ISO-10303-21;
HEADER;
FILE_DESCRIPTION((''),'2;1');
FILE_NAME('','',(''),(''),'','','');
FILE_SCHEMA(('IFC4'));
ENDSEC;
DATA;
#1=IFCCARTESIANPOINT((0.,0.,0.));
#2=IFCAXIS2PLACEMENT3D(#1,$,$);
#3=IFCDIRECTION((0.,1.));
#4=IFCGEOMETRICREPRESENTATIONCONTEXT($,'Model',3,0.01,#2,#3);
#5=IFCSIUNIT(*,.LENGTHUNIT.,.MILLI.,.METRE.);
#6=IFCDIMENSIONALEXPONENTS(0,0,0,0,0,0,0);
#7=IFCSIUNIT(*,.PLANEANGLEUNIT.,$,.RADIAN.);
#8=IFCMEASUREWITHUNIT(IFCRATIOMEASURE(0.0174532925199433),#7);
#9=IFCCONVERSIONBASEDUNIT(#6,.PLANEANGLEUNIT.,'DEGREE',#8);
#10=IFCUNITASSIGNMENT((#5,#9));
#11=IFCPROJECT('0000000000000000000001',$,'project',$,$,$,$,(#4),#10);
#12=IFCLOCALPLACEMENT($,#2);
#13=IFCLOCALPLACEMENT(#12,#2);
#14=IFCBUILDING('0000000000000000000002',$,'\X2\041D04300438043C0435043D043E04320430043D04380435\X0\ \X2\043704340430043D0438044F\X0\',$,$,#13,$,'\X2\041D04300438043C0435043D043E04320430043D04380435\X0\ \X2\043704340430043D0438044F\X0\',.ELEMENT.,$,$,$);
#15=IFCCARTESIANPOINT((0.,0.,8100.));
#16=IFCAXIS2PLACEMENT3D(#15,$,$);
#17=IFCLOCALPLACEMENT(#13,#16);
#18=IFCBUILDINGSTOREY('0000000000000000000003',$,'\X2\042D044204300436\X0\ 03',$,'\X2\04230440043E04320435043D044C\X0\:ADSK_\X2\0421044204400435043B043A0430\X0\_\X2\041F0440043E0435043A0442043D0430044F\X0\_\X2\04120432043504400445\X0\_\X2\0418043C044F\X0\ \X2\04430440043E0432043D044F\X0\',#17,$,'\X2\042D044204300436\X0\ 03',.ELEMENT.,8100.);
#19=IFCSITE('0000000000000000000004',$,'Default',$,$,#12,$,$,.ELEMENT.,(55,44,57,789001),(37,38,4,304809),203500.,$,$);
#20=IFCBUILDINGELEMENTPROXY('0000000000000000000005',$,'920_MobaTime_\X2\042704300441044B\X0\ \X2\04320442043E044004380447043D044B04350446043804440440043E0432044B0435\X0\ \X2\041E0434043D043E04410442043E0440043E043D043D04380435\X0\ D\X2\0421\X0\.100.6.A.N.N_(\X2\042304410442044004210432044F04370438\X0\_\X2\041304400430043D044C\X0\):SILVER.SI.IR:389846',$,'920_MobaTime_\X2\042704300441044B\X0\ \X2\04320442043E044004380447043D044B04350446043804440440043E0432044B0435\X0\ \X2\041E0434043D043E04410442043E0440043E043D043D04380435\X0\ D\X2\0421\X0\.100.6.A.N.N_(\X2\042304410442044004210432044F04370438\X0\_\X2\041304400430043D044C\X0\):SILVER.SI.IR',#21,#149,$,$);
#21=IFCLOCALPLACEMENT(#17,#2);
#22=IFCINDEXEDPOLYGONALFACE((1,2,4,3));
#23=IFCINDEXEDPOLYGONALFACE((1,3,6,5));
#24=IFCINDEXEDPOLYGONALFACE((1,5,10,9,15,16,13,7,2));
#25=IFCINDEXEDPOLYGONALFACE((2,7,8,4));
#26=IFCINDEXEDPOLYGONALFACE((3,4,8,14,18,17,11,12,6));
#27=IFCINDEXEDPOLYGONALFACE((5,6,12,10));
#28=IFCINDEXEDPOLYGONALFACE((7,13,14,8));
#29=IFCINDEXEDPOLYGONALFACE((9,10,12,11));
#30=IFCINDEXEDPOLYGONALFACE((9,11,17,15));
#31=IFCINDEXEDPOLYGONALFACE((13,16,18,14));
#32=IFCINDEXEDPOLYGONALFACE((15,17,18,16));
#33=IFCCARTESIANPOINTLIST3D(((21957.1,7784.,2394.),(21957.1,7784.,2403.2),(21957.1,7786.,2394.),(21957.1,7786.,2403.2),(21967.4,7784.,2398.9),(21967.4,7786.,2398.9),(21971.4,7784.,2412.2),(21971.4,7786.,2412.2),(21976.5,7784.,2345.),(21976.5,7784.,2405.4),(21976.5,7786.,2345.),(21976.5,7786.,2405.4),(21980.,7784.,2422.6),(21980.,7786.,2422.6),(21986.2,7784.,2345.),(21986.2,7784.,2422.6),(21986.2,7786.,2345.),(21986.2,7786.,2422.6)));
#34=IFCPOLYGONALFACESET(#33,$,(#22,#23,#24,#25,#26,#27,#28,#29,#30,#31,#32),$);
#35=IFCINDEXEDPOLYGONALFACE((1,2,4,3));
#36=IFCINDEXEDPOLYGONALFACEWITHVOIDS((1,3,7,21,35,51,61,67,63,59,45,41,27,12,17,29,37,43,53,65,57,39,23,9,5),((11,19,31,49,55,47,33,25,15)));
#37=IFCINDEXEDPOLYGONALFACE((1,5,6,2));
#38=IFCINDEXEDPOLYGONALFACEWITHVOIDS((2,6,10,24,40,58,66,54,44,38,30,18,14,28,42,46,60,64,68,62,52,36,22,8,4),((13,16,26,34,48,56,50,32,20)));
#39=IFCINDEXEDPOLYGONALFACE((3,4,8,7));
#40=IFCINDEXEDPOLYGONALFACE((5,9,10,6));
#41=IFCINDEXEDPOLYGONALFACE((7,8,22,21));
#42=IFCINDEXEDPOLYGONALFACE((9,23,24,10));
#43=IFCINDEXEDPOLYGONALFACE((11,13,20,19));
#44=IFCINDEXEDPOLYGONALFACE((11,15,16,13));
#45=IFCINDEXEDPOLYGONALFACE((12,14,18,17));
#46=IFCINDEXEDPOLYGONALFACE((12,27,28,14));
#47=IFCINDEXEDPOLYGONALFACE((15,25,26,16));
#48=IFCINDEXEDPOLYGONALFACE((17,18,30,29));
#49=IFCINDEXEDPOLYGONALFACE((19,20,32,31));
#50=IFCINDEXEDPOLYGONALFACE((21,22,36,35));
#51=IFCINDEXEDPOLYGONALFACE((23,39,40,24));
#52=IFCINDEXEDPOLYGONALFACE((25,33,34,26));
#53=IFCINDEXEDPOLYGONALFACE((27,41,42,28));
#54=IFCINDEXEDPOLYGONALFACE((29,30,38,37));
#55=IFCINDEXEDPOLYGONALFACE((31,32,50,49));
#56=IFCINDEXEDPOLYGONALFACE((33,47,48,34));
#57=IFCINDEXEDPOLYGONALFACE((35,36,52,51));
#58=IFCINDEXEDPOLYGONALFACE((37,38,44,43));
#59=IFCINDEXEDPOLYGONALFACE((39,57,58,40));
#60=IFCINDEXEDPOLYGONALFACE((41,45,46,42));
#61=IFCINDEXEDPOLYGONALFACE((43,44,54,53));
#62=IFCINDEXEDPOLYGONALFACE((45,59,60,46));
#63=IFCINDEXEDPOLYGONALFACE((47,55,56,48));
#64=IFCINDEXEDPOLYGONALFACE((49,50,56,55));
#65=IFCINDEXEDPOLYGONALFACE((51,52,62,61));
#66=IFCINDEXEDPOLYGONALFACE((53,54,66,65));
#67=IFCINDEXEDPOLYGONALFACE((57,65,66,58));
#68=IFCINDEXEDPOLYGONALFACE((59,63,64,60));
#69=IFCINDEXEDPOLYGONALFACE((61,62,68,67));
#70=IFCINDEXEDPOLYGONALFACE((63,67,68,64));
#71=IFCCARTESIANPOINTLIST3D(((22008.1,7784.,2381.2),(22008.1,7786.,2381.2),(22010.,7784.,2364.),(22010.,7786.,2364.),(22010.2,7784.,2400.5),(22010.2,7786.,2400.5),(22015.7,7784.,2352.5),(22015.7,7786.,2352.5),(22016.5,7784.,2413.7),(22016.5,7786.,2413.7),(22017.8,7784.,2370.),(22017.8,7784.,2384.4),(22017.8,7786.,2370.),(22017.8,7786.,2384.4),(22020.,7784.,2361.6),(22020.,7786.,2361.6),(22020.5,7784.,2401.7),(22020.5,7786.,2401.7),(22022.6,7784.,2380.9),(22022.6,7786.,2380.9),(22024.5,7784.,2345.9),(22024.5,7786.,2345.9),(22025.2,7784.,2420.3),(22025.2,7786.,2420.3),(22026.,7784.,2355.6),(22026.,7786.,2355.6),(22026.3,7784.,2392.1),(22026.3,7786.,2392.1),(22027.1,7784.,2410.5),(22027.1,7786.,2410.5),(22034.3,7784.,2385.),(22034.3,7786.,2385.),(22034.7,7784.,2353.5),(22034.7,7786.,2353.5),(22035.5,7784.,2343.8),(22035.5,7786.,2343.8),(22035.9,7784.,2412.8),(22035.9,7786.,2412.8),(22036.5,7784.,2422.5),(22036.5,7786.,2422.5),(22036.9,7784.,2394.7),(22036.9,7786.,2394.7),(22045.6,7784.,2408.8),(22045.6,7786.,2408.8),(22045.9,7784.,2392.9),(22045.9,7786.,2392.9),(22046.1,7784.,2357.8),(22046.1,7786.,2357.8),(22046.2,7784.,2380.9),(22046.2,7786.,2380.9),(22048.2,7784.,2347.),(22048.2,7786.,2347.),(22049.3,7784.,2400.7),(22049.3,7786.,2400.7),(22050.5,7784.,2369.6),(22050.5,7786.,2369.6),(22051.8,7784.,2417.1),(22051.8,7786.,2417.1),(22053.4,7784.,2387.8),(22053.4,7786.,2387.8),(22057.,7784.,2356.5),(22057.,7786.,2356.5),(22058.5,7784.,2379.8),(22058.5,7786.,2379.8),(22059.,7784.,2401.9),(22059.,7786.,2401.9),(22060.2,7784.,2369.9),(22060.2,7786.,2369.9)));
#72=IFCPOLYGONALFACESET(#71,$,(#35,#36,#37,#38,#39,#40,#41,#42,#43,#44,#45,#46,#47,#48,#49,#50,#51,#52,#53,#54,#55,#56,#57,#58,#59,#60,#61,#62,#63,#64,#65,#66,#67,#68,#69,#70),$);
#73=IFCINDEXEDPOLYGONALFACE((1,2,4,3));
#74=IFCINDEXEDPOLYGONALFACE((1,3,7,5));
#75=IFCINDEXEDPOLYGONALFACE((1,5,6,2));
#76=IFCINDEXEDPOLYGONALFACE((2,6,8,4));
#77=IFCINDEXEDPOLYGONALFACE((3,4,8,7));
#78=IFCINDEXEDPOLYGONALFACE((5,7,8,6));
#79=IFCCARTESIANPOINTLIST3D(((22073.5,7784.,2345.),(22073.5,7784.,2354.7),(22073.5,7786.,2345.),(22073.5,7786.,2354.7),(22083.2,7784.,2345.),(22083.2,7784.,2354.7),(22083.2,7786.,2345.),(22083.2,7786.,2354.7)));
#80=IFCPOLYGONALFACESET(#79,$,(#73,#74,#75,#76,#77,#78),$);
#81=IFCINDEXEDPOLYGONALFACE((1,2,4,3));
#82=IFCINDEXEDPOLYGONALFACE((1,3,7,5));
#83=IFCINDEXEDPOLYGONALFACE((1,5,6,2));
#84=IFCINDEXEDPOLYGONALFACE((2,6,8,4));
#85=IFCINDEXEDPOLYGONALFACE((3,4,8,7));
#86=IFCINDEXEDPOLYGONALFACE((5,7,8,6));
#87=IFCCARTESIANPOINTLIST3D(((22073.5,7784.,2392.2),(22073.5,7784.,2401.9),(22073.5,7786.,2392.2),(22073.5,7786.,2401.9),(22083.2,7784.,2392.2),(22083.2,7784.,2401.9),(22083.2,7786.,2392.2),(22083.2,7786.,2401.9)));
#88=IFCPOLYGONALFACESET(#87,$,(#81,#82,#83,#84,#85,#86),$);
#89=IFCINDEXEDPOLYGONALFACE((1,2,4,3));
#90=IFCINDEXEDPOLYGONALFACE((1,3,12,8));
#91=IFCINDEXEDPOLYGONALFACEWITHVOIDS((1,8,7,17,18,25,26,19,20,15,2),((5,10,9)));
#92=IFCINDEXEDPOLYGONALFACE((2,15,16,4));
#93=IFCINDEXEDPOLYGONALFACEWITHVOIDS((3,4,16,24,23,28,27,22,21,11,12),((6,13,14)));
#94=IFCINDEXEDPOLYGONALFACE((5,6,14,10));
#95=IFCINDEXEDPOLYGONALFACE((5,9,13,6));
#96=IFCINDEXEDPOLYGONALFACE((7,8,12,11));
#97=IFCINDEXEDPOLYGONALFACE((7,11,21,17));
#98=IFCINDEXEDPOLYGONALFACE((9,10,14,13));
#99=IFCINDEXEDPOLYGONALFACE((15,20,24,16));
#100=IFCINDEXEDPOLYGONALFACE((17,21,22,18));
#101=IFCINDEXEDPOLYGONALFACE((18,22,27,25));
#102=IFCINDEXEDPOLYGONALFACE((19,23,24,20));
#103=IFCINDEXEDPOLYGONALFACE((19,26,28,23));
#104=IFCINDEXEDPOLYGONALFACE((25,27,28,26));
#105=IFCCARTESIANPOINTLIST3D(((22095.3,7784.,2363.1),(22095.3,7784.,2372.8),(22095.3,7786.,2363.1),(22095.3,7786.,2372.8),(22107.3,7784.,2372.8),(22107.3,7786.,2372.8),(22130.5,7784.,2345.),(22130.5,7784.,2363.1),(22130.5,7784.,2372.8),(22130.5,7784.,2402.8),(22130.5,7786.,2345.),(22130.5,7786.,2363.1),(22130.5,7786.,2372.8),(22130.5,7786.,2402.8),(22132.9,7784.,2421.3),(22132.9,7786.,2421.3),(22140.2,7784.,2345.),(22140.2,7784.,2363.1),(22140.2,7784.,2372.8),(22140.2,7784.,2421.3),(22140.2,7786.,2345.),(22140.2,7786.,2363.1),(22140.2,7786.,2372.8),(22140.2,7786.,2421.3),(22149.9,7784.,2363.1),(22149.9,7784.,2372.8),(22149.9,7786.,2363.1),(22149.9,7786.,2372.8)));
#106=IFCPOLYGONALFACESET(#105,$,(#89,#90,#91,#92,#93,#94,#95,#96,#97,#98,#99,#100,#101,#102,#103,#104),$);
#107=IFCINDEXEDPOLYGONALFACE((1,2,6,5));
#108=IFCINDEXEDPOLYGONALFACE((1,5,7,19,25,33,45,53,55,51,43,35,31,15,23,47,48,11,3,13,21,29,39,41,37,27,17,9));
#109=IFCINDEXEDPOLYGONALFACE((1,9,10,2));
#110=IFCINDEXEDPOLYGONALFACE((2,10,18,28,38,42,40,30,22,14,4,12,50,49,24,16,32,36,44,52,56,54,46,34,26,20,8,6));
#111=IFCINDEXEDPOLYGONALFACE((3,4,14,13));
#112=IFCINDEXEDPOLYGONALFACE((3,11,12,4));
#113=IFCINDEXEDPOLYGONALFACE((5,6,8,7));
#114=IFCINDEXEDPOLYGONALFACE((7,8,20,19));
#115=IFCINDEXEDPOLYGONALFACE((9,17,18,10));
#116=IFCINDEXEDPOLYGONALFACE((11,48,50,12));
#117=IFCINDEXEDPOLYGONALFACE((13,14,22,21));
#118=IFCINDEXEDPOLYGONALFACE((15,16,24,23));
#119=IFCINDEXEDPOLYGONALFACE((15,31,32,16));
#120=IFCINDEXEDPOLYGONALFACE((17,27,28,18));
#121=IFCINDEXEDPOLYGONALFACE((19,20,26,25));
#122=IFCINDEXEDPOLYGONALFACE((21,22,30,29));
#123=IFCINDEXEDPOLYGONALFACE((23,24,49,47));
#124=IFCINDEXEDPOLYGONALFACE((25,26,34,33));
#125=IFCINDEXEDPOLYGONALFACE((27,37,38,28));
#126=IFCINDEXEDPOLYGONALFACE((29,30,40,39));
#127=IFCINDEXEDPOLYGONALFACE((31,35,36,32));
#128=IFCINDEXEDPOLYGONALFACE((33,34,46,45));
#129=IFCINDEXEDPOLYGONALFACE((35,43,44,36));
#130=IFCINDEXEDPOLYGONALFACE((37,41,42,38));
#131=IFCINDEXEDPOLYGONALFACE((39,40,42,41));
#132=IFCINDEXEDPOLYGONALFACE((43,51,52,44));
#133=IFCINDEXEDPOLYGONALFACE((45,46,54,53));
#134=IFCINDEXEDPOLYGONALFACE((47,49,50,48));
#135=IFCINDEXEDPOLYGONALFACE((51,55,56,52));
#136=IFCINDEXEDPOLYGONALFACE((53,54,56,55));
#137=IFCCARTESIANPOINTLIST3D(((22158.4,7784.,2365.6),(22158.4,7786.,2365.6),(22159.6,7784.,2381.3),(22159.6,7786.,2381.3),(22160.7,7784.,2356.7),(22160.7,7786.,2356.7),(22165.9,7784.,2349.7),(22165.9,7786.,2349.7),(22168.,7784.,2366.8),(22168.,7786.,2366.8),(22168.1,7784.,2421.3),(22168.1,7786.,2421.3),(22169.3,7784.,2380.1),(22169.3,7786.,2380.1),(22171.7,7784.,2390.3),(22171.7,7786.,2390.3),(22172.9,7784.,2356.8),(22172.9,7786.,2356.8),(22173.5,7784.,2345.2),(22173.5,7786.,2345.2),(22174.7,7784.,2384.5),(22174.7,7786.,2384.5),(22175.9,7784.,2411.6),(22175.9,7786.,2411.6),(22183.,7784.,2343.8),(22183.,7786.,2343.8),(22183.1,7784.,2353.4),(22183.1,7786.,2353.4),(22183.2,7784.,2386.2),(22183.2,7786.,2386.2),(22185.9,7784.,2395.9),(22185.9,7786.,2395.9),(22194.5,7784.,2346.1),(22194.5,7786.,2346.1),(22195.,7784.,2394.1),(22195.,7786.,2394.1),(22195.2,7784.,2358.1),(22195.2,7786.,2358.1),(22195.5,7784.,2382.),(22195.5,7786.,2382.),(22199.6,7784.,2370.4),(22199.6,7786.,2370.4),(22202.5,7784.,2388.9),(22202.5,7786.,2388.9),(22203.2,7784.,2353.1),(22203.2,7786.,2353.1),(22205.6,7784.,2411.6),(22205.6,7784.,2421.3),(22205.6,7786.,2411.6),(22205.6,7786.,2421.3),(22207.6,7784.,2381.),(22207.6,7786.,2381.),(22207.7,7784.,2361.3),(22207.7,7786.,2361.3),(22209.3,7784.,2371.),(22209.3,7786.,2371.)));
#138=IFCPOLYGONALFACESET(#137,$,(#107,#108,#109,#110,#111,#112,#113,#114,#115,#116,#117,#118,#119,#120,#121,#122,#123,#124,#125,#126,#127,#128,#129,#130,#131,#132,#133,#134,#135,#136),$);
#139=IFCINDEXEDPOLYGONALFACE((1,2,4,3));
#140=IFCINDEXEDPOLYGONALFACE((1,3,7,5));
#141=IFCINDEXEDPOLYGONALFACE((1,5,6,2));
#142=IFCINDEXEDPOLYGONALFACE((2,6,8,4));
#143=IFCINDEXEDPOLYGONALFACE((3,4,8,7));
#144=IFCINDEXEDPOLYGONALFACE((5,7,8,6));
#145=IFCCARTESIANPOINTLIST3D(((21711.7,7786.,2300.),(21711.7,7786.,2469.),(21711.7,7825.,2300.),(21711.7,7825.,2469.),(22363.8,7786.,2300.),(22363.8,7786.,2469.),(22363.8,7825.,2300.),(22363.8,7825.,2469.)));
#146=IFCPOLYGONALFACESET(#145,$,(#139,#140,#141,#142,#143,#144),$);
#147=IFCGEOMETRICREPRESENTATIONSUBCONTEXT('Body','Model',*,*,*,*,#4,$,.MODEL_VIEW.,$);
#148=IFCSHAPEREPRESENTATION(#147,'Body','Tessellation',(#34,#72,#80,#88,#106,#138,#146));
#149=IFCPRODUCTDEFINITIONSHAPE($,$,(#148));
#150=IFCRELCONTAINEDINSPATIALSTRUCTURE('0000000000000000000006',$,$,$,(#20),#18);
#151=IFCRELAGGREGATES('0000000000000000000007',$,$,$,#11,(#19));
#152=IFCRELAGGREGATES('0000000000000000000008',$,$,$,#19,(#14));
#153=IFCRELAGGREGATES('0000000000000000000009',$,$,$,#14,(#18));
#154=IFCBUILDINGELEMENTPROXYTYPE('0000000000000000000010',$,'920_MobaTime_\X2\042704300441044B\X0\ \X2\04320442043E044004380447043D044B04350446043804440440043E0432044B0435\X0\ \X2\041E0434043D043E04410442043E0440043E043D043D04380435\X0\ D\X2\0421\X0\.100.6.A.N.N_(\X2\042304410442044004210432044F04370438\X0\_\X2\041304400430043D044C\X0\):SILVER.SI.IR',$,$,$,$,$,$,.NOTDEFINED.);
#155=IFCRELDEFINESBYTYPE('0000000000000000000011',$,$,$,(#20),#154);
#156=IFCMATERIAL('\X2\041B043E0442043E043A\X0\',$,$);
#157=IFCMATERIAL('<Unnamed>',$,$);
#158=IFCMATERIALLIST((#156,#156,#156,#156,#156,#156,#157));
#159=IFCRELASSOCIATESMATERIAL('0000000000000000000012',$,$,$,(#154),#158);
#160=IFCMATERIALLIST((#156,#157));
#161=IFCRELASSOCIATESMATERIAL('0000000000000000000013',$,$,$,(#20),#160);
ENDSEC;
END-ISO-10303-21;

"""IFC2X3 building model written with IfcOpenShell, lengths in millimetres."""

from ifc_helpers import new_model, entity, si_unit, converted_unit, direction, frame, origin, origin_2d_with_axis, place, context, subcontext, project, spatial, polyline, rectangle, outline, extrude, source, transform, mapped, material, material_list, type_object, type_shapes, element, save


model = new_model("IFC2X3")

# Units and contexts
model_context = context("Model", 3, precision=0.01, world=origin(), true_north=direction((0.0, 1.0)))
body_context = subcontext(model_context, "Body", "Model", "MODEL_VIEW")
ifc_project = project(units=[si_unit("LENGTHUNIT", "METRE", prefix="MILLI"), converted_unit("PLANEANGLEUNIT", "DEGREE", entity("IfcRatioMeasure", 0.0174532925199433), si_unit("PLANEANGLEUNIT", "RADIAN"), dimensions=[0, 0, 0, 0, 0, 0, 0])], contexts=[model_context])

# Site, building, storey
site_placement = place(None, origin())
site = spatial("IfcSite", under=ifc_project, at=site_placement, Name="Default", CompositionType="ELEMENT", RefLatitude=(55, 44, 57, 789001), RefLongitude=(37, 38, 4, 304809), RefElevation=203500.0)
building_placement = place(site_placement, origin())
building = spatial("IfcBuilding", under=site, at=building_placement, Name="Наименование здания", LongName="Наименование здания", CompositionType="ELEMENT")
storey_placement = place(building_placement, frame((0.0, 0.0, 8100.0)))
storey = spatial("IfcBuildingStorey", under=building, at=storey_placement, Name="Этаж 03", ObjectType="Уровень:ADSK_Стрелка_Проектная_Вверх_Имя уровня", LongName="Этаж 03", CompositionType="ELEMENT", Elevation=8100.0)

# Building element proxy
ifc_material_1 = material(Name="Лоток")
ifc_material_2 = material(Name="<Unnamed>")
ifc_material_list_1 = material_list([ifc_material_1, ifc_material_1, ifc_material_1, ifc_material_1, ifc_material_1, ifc_material_1, ifc_material_2])
building_element_proxy_type = type_object("IfcBuildingElementProxyType", Name="920_MobaTime_Часы вторичныецифровые Односторонние DС.100.6.A.N.N_(УстрСвязи_Грань):SILVER.SI.IR", PredefinedType="NOTDEFINED", material=ifc_material_list_1)
shared_shape = source(origin(), body_context, "Body", "SweptSolid", [
    extrude(outline(polyline([(-49.3, -13.1), (28.2, -13.1), (28.2, -6.8), (17.9, 1.8), (8.8, 16.0), (-0.3, 16.0), (4.6, 5.8), (11.1, -3.4), (-49.3, -3.4), (-49.3, -13.1)])), frame((-64.6, 9.8, 39.0), z_axis=(0.0, 0.0, 1.0), x_axis=(0.0, 1.0, 0.0)), (0.0, 0.0, 1.0), 2.0),
    extrude(outline(polyline([(2.2, -27.6), (19.0, -27.6), (30.5, -16.1), (33.3, -4.9), (31.0, 5.8), (21.8, 17.2), (5.2, 27.3), (-11.1, 33.0), (-24.0, 32.7), (-33.6, 27.6), (-40.3, 18.6), (-42.8, 5.7), (-38.0, -6.3), (-27.2, -14.9), (-17.5, -17.7), (-8.2, -16.4), (-0.3, -11.9), (5.1, -4.5), (7.3, 6.2), (4.0, 17.2), (18.4, 7.3), (23.6, -2.4), (22.0, -11.4), (14.2, -18.4), (5.3, -18.3), (2.2, -27.6)]), holes=[polyline([(-9.0, 23.3), (-1.3, 14.3), (-2.5, 2.0), (-11.4, -7.0), (-23.4, -6.0), (-32.2, 2.9), (-31.2, 15.1), (-25.6, 22.1), (-17.5, 24.9), (-9.0, 23.3)])]), frame((-2.7, 3.6, 39.0), z_axis=(0.0, 0.0, 1.0), x_axis=(-0.427649, 0.903945, 0.0)), (0.0, 0.0, 1.0), 2.0),
    extrude(rectangle(XDim=9.7, YDim=9.7, at=origin_2d_with_axis()), frame((40.6, -34.7, 39.0)), (0.0, 0.0, 1.0), 2.0),
    extrude(rectangle(XDim=9.7, YDim=9.7, at=origin_2d_with_axis()), frame((40.6, 12.6, 39.0)), (0.0, 0.0, 1.0), 2.0),
    extrude(outline(polyline([(-0.9, -28.1), (8.8, -28.1), (8.8, -9.9), (18.5, -9.9), (18.5, -0.2), (8.8, -0.2), (8.8, 48.3), (1.5, 48.3), (-36.0, -0.2), (-36.0, -9.9), (-0.9, -9.9), (-0.9, -28.1)]), holes=[polyline([(-0.9, -0.2), (-24.1, -0.2), (-0.9, 29.7), (-0.9, -0.2)])]), frame((93.6, -11.4, 39.0)), (0.0, 0.0, 1.0), 2.0),
    extrude(outline(polyline([(3.3, -28.3), (12.5, -28.3), (20.5, -25.0), (26.8, -18.9), (30.7, -10.0), (31.4, 1.6), (26.9, 11.8), (20.1, 18.4), (11.1, 22.3), (1.0, 23.3), (-7.9, 20.4), (-14.9, 14.5), (-18.9, 6.2), (-17.1, -9.0), (-36.7, 0.5), (-29.1, 29.2), (-38.5, 31.7), (-48.1, -4.6), (-11.6, -23.1), (-8.0, -14.0), (-10.8, -7.6), (-10.2, 1.1), (-3.0, 11.8), (9.2, 12.8), (20.0, 5.5), (21.4, -7.5), (15.5, -16.4), (4.6, -18.6), (3.3, -28.3)])), frame((147.1, -8.5, 39.0), z_axis=(0.0, 0.0, 1.0), x_axis=(0.256974, -0.966418, 0.0)), (0.0, 0.0, 1.0), 2.0),
    extrude(rectangle(XDim=652.0, YDim=169.0, at=origin_2d_with_axis()), frame((0.0, 0.0, 0.0), z_axis=(0.0, 0.0, 1.0), x_axis=(-1.0, 0.0, 0.0)), (0.0, 0.0, 1.0), 39.0),
])
type_shapes(building_element_proxy_type, [shared_shape])
ifc_material_list_2 = material_list([ifc_material_1, ifc_material_2])
for number, where, z_axis, x_axis, name in (
    (1, (22037.8, 7825.0, 2384.5), (0.0, -1.0, 0.0), (1.0, 0.0, 0.0), "920_MobaTime_Часы вторичныецифровые Односторонние DС.100.6.A.N.N_(УстрСвязи_Грань):SILVER.SI.IR:389846"),
):
    element("IfcBuildingElementProxy", number, at=place(storey_placement, frame(where, z_axis=z_axis, x_axis=x_axis)), inside=storey, type_object=building_element_proxy_type, material=ifc_material_list_2, Name=name, ObjectType="920_MobaTime_Часы вторичныецифровые Односторонние DС.100.6.A.N.N_(УстрСвязи_Грань):SILVER.SI.IR", context=body_context, shape_type="MappedRepresentation", body=[
        mapped(shared_shape, transform((0.0, 0.0, 0.0), scale=1.0)),
    ])

save(model, "model.ifc")
